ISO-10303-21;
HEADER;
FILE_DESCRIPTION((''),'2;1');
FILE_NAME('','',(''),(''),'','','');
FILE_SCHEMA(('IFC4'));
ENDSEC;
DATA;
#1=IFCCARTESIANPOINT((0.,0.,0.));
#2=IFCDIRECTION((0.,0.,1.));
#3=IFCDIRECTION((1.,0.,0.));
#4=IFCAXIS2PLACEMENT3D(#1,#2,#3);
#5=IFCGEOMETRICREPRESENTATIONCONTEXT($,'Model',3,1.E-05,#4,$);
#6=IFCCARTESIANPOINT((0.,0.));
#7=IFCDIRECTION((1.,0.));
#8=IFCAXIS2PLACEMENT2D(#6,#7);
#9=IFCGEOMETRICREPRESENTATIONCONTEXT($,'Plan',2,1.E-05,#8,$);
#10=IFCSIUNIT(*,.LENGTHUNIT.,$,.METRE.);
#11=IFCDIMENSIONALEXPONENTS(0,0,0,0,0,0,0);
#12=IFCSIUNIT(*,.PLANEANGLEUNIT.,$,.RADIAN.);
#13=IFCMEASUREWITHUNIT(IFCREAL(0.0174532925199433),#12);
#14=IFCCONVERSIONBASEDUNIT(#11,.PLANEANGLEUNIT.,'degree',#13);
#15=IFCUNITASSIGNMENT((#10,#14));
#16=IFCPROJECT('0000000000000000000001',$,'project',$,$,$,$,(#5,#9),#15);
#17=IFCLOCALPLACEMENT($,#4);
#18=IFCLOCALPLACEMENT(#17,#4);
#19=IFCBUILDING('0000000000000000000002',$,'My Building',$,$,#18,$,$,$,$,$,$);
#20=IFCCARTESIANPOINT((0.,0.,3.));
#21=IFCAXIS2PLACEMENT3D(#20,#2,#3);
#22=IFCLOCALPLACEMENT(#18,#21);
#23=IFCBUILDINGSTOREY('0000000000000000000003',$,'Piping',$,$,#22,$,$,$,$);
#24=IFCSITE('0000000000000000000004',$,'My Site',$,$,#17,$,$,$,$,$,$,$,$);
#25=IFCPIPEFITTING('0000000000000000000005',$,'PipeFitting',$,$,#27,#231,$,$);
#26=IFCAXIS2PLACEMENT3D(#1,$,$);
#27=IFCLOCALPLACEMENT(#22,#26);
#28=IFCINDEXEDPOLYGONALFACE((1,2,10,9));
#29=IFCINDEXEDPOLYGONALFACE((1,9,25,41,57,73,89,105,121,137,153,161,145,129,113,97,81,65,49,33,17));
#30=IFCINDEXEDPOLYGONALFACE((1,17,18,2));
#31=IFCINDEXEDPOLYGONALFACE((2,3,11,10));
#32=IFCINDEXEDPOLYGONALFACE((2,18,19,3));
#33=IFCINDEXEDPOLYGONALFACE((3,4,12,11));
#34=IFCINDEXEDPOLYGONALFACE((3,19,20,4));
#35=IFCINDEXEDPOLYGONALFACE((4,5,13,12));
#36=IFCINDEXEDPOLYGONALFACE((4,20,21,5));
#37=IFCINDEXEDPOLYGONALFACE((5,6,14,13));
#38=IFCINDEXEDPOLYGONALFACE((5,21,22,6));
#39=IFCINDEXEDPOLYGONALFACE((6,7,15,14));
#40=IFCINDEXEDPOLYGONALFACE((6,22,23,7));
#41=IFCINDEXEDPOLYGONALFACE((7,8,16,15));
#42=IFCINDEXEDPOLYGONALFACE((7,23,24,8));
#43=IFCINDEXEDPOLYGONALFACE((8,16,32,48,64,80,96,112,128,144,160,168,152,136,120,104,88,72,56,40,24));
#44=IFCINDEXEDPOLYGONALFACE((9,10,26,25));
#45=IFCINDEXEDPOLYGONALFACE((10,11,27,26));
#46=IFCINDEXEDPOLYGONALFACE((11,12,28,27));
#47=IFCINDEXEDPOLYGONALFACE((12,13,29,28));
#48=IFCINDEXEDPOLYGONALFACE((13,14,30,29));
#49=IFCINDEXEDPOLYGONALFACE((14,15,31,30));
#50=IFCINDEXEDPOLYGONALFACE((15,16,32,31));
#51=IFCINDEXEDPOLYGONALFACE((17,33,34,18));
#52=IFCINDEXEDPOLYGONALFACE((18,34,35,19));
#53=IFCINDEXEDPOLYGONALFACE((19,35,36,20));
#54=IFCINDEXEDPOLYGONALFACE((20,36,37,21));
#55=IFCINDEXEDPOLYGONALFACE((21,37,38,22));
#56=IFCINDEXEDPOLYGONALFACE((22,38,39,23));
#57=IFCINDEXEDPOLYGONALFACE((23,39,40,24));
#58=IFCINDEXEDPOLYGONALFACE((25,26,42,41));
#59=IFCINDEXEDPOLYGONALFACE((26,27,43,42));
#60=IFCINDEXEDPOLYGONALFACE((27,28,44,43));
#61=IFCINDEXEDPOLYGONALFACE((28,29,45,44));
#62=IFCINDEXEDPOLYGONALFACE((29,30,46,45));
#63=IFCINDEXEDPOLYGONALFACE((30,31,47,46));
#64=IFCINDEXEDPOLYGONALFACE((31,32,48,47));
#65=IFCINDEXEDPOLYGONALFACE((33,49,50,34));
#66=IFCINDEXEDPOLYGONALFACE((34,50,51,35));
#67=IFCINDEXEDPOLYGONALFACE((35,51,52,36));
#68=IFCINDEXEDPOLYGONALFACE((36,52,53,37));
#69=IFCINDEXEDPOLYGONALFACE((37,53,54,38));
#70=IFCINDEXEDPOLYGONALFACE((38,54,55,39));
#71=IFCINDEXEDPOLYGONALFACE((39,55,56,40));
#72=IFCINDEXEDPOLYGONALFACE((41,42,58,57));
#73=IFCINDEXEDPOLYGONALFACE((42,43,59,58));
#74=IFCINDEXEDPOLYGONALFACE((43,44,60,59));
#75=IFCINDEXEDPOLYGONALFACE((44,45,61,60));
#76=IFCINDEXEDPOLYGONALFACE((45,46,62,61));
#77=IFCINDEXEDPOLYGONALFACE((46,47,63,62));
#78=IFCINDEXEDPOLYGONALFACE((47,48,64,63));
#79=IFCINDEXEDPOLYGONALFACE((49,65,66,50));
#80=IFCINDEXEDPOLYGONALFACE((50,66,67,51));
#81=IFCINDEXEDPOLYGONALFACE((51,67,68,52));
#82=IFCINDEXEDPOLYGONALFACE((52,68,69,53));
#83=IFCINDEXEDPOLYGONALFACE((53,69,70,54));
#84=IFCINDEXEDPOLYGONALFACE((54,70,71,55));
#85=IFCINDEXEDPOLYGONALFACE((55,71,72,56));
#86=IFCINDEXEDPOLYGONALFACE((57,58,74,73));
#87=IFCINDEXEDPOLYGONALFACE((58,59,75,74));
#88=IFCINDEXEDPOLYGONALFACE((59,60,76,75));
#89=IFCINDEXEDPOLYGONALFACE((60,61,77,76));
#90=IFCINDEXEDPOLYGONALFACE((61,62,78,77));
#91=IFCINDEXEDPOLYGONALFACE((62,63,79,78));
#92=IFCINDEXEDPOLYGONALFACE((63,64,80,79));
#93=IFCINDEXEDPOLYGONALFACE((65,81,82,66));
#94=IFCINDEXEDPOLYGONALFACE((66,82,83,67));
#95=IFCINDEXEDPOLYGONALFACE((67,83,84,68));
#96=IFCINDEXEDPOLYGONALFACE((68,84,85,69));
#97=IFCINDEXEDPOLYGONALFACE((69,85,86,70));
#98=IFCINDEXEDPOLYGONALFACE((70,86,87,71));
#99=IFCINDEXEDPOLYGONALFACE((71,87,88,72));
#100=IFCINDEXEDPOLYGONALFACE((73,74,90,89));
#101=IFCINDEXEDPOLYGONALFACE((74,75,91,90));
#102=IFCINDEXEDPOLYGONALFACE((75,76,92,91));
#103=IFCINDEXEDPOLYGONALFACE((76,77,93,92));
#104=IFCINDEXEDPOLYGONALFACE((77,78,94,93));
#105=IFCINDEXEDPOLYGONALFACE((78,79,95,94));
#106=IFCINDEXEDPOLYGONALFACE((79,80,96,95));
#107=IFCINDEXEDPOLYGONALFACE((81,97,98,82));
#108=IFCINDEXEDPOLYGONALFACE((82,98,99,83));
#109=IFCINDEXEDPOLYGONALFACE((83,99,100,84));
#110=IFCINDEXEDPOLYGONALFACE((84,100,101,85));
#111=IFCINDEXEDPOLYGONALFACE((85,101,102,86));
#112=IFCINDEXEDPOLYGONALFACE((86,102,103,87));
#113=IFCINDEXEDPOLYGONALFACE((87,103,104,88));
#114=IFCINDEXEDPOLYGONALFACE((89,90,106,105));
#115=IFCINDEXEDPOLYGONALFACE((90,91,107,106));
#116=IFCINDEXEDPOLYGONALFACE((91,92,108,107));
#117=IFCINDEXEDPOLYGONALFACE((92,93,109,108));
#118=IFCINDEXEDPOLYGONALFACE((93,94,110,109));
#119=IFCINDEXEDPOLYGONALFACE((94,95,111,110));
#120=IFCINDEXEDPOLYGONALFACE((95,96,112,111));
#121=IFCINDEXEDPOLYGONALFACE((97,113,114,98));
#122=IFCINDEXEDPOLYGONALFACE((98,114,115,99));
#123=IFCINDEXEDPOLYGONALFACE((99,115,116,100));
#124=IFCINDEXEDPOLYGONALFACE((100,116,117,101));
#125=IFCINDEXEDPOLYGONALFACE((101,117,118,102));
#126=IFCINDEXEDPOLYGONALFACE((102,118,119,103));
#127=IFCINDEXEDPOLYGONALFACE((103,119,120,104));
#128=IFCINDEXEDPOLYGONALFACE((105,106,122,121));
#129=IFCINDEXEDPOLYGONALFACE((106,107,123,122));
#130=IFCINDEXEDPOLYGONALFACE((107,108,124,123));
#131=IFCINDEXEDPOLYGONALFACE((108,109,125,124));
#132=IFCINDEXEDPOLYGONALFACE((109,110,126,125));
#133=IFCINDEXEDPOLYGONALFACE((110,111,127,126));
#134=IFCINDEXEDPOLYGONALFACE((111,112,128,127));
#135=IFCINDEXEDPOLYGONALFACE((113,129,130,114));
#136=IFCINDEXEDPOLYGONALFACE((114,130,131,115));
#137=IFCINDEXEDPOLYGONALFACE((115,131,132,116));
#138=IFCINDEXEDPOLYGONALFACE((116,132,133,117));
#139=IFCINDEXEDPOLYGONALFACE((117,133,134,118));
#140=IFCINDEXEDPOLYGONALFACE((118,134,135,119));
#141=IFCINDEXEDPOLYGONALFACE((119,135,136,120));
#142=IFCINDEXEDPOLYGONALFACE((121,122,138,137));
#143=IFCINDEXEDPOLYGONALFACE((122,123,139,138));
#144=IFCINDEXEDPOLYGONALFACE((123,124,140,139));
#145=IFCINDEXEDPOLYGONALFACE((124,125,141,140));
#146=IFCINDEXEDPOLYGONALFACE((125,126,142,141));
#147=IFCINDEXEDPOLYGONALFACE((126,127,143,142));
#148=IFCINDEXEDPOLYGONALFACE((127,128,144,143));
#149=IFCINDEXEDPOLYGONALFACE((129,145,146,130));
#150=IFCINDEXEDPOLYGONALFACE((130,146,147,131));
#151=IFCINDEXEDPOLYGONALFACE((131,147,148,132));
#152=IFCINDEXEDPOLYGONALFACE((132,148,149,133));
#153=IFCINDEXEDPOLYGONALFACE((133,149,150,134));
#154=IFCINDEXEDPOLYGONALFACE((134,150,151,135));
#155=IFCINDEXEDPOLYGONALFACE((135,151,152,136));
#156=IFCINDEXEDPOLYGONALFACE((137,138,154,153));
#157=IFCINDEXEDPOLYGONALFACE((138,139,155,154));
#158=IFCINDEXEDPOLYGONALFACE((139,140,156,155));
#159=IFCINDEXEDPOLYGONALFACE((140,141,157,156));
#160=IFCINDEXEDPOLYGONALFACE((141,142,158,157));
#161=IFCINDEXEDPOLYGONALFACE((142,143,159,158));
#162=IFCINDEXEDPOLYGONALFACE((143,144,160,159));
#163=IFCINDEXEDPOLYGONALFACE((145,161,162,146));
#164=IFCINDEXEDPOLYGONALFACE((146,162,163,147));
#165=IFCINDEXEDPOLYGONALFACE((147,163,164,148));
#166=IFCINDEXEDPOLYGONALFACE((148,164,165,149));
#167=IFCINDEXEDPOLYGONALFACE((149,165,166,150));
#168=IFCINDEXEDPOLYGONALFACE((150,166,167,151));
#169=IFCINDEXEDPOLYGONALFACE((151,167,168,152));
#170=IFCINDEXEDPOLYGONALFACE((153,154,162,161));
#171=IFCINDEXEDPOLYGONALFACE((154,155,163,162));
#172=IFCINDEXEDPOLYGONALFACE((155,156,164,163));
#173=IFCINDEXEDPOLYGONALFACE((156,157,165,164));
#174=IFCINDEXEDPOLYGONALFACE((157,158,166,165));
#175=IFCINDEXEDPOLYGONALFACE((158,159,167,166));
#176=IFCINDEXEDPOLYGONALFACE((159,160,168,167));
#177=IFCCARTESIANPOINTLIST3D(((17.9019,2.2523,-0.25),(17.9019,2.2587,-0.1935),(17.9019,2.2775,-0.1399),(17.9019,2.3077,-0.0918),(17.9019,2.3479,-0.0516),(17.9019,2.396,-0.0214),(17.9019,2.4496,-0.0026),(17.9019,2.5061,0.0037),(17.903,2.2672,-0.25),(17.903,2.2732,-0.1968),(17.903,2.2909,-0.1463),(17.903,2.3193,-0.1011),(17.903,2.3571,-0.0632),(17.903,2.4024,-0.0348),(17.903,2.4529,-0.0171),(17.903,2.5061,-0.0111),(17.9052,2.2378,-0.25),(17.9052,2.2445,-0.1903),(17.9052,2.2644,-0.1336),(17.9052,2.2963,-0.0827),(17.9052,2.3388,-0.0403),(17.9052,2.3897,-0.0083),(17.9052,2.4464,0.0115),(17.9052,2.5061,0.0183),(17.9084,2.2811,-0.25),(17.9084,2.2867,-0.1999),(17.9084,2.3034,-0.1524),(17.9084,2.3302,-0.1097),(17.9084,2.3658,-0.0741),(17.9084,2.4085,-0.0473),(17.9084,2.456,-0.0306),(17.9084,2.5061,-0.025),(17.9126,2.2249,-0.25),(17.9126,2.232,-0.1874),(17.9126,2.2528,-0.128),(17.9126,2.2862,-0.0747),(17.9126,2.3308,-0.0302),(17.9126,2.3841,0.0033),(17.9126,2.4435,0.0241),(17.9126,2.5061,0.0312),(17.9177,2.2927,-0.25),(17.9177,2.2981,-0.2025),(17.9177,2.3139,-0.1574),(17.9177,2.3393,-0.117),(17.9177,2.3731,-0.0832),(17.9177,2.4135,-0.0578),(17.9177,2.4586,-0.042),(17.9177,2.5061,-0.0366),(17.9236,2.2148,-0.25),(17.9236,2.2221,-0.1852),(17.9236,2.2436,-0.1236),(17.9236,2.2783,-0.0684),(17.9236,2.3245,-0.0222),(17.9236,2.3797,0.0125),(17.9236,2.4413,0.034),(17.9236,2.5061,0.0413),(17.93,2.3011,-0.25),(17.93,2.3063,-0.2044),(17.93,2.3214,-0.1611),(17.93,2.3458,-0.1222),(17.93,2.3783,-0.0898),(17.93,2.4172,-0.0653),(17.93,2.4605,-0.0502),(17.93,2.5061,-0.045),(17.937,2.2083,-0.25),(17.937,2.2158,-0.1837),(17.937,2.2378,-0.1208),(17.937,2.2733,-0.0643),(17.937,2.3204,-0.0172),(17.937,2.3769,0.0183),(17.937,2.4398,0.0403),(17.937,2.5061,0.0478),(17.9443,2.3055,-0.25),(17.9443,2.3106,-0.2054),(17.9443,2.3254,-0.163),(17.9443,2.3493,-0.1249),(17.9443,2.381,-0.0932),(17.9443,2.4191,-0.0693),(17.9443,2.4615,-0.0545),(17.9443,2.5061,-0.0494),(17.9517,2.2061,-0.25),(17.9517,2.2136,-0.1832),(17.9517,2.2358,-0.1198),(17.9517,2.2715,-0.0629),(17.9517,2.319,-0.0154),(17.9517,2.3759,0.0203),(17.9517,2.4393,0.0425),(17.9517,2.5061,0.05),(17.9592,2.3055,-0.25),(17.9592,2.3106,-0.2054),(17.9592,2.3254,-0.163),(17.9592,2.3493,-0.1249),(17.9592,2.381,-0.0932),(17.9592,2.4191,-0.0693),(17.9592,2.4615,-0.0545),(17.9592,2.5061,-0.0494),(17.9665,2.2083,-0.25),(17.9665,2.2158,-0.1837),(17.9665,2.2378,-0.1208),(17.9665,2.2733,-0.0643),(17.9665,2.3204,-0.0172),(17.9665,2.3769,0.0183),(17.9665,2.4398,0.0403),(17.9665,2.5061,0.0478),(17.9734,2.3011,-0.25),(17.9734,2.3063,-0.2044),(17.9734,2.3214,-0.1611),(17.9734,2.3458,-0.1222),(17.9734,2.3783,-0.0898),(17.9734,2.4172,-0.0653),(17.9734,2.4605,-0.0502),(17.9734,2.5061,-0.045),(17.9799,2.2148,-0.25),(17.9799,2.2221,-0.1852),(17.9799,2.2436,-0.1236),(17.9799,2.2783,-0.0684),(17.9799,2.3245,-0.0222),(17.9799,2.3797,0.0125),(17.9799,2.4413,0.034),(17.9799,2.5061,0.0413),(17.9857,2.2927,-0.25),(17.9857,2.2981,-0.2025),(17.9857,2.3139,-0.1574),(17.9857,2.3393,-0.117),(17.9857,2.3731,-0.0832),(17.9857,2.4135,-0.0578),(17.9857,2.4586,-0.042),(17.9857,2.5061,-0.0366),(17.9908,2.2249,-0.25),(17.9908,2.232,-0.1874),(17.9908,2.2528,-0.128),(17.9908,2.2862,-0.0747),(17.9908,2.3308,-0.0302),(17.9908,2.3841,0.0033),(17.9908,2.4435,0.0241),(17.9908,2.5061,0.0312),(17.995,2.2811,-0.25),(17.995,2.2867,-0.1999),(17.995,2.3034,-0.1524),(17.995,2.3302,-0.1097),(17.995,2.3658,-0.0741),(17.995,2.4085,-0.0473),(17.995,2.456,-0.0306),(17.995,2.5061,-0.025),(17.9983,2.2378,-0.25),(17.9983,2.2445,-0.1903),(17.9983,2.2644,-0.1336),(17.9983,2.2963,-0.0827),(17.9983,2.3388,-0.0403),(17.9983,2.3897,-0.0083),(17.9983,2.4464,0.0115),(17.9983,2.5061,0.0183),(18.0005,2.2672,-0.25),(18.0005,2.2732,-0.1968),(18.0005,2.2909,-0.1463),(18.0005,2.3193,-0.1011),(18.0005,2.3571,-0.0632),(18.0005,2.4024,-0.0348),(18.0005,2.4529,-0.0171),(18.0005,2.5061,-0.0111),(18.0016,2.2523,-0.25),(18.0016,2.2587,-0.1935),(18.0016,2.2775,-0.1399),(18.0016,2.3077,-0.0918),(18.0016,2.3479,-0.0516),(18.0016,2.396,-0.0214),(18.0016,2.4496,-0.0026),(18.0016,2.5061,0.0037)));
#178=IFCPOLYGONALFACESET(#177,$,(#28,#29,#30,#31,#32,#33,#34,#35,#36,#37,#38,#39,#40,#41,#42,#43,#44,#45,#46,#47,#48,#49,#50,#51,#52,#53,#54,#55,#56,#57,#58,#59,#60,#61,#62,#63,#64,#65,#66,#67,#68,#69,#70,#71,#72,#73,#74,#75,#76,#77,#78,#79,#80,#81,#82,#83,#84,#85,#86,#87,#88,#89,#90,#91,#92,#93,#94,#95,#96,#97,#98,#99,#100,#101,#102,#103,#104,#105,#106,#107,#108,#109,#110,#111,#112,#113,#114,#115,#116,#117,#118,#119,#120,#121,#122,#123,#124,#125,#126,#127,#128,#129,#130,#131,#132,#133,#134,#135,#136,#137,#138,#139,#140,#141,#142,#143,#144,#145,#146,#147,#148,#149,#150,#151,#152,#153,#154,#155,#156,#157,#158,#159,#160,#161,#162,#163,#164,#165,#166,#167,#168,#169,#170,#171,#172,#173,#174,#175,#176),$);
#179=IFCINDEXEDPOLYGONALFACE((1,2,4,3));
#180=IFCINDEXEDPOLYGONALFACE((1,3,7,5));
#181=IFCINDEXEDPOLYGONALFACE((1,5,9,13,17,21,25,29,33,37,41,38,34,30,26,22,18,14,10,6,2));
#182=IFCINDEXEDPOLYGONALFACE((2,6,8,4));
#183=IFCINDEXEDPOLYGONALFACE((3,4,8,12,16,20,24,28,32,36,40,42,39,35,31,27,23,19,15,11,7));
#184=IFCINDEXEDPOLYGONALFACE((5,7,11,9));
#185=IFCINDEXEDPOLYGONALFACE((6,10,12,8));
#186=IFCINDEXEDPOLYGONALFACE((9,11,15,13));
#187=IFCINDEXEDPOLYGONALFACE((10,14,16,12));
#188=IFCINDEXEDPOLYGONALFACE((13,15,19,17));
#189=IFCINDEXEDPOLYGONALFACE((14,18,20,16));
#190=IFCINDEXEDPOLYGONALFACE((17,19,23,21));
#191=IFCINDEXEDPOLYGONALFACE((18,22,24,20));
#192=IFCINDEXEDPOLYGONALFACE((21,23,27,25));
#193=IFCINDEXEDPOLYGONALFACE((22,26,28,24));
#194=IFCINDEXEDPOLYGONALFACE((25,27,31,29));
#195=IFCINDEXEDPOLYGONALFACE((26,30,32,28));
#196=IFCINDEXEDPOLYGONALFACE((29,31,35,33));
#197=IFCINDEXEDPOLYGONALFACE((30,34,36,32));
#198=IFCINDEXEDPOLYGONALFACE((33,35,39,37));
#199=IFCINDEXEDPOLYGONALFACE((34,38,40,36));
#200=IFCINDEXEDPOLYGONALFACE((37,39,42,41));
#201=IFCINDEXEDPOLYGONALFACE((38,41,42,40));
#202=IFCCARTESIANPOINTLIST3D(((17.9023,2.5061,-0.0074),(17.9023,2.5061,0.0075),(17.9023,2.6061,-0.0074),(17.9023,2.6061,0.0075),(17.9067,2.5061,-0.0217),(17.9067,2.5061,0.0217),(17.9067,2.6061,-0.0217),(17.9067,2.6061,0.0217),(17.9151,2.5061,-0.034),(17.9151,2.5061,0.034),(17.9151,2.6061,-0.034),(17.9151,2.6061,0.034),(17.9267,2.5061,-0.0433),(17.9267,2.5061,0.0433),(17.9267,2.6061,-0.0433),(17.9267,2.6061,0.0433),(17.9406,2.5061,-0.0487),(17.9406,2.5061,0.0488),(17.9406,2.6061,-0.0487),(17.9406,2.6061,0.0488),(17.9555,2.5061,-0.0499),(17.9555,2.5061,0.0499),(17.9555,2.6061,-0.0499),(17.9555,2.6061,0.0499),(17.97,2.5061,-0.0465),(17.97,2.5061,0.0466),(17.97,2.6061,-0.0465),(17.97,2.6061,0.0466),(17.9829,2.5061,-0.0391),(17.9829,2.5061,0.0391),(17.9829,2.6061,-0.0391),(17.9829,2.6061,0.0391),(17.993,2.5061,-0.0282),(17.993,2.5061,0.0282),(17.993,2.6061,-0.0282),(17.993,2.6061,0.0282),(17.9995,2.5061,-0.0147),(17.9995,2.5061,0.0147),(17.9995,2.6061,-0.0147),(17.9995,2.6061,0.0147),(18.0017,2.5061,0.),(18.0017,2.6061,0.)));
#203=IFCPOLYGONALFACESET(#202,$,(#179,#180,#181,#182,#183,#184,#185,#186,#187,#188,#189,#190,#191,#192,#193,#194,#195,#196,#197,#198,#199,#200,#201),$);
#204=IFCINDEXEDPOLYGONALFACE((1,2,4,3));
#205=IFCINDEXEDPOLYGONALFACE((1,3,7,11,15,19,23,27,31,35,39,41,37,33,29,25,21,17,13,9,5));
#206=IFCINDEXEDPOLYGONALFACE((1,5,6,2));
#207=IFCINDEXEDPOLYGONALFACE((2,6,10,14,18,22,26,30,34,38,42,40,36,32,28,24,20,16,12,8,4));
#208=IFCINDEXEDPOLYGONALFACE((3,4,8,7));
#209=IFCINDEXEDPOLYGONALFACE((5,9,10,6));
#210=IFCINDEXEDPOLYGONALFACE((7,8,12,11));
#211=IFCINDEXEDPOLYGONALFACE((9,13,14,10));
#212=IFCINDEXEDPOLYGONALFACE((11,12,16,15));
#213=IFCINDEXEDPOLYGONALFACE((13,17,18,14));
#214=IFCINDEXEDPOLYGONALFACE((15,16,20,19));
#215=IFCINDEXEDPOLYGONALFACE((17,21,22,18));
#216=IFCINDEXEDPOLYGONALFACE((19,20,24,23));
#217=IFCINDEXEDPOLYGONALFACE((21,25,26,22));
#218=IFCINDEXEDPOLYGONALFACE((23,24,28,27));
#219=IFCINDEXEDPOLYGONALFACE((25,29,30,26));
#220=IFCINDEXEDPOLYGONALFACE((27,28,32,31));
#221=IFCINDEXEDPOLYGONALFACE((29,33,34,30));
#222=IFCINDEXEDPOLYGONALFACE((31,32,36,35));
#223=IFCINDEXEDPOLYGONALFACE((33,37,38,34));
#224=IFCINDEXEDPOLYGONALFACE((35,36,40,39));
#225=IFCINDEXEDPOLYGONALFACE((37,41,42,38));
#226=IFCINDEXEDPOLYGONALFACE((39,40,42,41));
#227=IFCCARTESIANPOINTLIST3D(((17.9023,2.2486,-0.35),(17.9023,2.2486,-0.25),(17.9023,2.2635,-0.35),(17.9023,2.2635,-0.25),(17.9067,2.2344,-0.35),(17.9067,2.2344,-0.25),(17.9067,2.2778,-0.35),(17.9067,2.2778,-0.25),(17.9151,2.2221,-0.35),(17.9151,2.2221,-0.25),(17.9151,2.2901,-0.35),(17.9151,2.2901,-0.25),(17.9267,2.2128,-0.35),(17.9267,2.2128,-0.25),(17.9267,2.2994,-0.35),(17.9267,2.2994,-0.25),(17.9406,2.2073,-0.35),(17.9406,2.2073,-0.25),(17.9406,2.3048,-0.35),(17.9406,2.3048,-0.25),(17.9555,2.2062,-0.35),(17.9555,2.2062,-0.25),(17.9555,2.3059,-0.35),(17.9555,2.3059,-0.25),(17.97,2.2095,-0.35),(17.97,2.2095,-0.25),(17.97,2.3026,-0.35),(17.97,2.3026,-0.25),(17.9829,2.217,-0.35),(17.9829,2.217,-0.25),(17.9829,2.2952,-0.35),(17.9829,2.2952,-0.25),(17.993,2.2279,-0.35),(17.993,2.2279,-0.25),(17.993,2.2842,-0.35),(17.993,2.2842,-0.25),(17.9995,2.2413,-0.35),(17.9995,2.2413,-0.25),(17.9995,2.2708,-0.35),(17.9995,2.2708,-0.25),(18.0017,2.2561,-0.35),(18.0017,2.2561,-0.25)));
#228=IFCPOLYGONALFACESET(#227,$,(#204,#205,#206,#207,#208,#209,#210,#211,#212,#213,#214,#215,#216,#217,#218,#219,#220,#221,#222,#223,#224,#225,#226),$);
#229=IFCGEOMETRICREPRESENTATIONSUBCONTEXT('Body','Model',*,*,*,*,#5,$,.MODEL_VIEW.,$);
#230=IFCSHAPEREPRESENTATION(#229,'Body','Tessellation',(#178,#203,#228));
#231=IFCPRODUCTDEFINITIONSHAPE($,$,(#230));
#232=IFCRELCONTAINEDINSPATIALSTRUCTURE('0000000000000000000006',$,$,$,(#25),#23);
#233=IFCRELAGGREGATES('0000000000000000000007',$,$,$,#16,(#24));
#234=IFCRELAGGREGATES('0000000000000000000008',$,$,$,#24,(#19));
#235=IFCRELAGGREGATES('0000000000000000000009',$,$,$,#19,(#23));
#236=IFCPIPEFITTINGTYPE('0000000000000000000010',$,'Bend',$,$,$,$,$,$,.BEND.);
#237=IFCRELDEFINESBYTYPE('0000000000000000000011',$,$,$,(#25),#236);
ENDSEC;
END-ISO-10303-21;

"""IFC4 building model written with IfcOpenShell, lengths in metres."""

from ifc_helpers import new_model, entity, si_unit, converted_unit, frame, origin_with_axes, origin_2d_with_axis, place, context, subcontext, project, spatial, circle, extrude, source, transform, mapped, type_object, type_shapes, element, save


model = new_model("IFC4")

# Units and contexts
model_context = context("Model", 3, precision=1e-05, world=origin_with_axes())
plan_context = context("Plan", 2, precision=1e-05, world=origin_2d_with_axis())
body_context = subcontext(model_context, "Body", "Model", "MODEL_VIEW")
ifc_project = project(units=[si_unit("LENGTHUNIT", "METRE"), converted_unit("PLANEANGLEUNIT", "degree", entity("IfcReal", 0.0174532925199433), si_unit("PLANEANGLEUNIT", "RADIAN"), dimensions=[0, 0, 0, 0, 0, 0, 0])], contexts=[model_context, plan_context])

# Site, building, storey
site_placement = place(None, origin_with_axes())
site = spatial("IfcSite", under=ifc_project, at=site_placement, Name="My Site")
building_placement = place(site_placement, origin_with_axes())
building = spatial("IfcBuilding", under=site, at=building_placement, Name="My Building")
storey_placement = place(building_placement, frame((0.0, 0.0, 3.0), z_axis=(0.0, 0.0, 1.0), x_axis=(1.0, 0.0, 0.0)))
storey = spatial("IfcBuildingStorey", under=building, at=storey_placement, Name="Piping")

# Pipe fitting
pipe_fitting_type = type_object("IfcPipeFittingType", Name="Bend", PredefinedType="BEND")
shared_shape = source(origin_with_axes(), body_context, "Body", "SolidModel", [
    entity("IfcSweptDiskSolid", entity("IfcIndexedPolyCurve", entity("IfcCartesianPointList3D", [[0.0, 0.0, 0.1], [0.0, -0.0732, 0.2768], [0.0, -0.25, 0.35]]), [entity("IfcArcIndex", [1, 2, 3])]), 0.05),
    extrude(circle(Radius=0.05), origin_with_axes(), (0.0, 0.0, 1.0), 0.1),
    extrude(circle(Radius=0.05), frame((0.0, -0.25, 0.35), z_axis=(0.0, -1.0, 0.0), x_axis=(1.0, 0.0, 0.0)), (0.0, 0.0, 1.0), 0.1),
])
type_shapes(pipe_fitting_type, [shared_shape])
for number, where, z_axis, x_axis, name in (
    (1, (17.9517, 2.6061, 0.0), (0.0, -1.0, 0.0), (1.0, 0.0, 0.0), "PipeFitting"),
):
    element("IfcPipeFitting", number, at=place(storey_placement, frame(where, z_axis=z_axis, x_axis=x_axis)), inside=storey, type_object=pipe_fitting_type, Name=name, context=body_context, shape_type="MappedRepresentation", body=[
        mapped(shared_shape, transform((0.0, 0.0, 0.0), x_axis=(1.0, 0.0, 0.0), y_axis=(0.0, 1.0, 0.0), z_axis=(0.0, 0.0, 1.0), scale=1.0)),
    ])

save(model, "model.ifc")
